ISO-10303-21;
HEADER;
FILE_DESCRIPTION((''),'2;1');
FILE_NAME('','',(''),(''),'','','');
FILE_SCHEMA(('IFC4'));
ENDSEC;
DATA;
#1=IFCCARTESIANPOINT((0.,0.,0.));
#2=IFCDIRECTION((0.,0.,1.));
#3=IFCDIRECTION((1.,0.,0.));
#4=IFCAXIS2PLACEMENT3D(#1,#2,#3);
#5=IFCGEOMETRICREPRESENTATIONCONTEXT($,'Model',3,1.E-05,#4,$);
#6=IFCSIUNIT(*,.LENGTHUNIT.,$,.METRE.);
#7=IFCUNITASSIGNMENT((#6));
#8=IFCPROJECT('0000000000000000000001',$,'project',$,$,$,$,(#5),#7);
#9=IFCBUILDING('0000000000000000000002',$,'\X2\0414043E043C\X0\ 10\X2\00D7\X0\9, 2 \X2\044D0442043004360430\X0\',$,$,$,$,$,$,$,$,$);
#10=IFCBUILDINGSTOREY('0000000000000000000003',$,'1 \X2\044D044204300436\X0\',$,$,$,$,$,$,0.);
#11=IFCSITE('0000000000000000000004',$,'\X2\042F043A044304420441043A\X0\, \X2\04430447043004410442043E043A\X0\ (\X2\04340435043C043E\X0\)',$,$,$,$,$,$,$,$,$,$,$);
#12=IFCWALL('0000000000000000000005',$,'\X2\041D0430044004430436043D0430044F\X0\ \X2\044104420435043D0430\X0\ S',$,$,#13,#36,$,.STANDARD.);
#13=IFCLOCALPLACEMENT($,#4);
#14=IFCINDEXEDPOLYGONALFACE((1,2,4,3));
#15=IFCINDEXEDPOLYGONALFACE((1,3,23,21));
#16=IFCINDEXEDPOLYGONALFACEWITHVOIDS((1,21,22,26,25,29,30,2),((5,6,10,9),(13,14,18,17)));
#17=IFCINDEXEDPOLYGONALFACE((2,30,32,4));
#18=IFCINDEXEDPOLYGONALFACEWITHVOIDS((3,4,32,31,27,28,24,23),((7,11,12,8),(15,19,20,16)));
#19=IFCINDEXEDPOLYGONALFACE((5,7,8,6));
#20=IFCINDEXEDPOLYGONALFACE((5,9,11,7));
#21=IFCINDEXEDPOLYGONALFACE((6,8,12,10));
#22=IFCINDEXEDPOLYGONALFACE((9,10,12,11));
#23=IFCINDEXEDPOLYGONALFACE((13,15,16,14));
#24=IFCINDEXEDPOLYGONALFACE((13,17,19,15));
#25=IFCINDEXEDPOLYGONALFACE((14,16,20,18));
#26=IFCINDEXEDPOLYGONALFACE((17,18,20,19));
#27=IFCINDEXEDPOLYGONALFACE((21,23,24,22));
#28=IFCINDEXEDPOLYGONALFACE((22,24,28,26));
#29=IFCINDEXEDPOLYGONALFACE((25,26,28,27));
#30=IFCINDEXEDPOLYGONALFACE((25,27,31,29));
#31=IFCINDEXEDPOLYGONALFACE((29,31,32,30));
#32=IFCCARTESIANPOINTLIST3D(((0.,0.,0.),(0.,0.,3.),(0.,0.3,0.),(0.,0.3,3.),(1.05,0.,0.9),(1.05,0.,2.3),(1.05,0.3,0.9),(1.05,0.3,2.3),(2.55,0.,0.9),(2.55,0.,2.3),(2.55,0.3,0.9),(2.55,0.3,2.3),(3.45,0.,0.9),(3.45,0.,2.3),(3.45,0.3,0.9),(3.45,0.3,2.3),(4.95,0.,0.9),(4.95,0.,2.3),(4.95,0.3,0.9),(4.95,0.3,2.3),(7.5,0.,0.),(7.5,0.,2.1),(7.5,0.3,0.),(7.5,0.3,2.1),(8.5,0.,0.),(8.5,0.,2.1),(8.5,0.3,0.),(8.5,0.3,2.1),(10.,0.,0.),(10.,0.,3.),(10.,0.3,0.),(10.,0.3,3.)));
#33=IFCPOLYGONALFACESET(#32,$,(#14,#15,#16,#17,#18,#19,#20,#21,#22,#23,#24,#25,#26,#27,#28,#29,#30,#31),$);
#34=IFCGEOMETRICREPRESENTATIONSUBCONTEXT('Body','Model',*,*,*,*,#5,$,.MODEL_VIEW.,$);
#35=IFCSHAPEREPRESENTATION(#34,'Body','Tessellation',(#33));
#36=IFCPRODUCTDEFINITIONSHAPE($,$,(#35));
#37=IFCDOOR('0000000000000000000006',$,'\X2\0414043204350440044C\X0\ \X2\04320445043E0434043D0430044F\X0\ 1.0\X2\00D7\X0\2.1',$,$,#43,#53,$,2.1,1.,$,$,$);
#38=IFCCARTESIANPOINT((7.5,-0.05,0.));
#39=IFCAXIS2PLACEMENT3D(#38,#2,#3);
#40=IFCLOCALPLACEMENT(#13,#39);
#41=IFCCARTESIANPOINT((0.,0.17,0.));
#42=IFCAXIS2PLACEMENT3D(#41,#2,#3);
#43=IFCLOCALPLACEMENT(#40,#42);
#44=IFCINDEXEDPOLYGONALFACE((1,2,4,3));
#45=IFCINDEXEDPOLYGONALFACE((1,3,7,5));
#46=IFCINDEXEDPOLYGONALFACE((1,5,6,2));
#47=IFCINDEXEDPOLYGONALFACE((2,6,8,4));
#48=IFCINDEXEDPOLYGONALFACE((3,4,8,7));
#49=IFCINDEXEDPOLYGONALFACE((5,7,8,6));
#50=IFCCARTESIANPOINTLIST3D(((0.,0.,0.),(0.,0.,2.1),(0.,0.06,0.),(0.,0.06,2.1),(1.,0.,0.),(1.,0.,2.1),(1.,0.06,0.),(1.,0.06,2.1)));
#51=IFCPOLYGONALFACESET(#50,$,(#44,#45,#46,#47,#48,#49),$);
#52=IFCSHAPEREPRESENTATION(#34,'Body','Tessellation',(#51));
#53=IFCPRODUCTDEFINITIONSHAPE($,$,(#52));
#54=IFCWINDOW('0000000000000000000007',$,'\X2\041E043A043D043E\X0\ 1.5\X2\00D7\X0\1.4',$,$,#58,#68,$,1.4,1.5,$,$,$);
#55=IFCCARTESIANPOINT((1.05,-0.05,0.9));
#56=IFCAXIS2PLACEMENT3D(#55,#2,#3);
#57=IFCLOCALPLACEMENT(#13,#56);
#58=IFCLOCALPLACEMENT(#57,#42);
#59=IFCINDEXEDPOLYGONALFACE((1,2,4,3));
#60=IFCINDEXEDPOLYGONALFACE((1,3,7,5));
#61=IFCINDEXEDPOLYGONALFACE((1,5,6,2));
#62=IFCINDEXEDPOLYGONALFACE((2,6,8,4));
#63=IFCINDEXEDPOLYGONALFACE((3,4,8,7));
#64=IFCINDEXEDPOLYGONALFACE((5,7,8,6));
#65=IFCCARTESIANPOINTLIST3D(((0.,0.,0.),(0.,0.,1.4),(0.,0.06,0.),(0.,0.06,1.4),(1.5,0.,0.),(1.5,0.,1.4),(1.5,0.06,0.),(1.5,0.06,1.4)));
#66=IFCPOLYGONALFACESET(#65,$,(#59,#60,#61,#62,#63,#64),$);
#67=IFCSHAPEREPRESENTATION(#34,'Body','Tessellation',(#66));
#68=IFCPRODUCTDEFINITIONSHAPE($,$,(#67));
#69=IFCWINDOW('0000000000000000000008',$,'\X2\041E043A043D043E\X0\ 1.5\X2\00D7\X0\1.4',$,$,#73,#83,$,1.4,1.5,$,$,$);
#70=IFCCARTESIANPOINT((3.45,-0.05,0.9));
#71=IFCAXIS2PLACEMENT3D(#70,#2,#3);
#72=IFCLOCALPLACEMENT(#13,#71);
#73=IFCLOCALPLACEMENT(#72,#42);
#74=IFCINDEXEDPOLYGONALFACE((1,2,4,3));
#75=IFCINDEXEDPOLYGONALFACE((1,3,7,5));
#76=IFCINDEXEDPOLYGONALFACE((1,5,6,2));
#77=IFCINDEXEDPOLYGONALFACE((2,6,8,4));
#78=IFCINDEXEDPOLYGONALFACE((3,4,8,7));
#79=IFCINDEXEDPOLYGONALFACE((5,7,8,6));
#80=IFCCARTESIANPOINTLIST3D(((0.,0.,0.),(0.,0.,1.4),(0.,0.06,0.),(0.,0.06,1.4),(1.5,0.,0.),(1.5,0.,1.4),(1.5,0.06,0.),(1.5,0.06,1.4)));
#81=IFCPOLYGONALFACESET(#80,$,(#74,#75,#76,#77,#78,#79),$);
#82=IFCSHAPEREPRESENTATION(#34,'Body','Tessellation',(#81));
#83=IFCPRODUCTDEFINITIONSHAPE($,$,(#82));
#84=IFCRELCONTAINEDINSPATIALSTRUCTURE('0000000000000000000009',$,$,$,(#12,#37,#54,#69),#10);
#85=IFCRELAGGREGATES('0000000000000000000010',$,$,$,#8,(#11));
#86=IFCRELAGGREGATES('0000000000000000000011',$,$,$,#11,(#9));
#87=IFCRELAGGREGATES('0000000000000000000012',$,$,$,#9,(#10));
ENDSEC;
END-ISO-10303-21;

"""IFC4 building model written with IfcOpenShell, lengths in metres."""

from ifc_helpers import new_model, si_unit, frame, origin_with_axes, place, context, subcontext, project, spatial, indexed_curve, outline, extrude, element, fill, save


model = new_model("IFC4")

# Units and contexts
model_context = context("Model", 3, precision=1e-05, world=origin_with_axes())
body_context = subcontext(model_context, "Body", "Model", "MODEL_VIEW")
ifc_project = project(units=[si_unit("LENGTHUNIT", "METRE")], contexts=[model_context])

# Site, building, storey
site = spatial("IfcSite", under=ifc_project, Name="Якутск, участок (демо)")
building = spatial("IfcBuilding", under=site, Name="Дом 10×9, 2 этажа")
storey = spatial("IfcBuildingStorey", under=building, Name="1 этаж", Elevation=0.0)

# Wall, openings, door, windows
wall_1_placement = place(None, origin_with_axes())
wall_1 = element("IfcWall", 1, at=wall_1_placement, inside=storey, Name="Наружная стена S", PredefinedType="STANDARD", context=body_context, shape_type="SweptSolid", body=[
    extrude(outline(indexed_curve([(0.0, 0.0), (0.0, 0.3), (10.0, 0.3), (10.0, 0.0), (0.0, 0.0)], self_intersect=False)), origin_with_axes(), (0.0, 0.0, 1.0), 3.0),
])
opening_1_placement = place(wall_1_placement, frame((7.5, -0.05, 0.0), z_axis=(0.0, 0.0, 1.0), x_axis=(1.0, 0.0, 0.0)))
opening_1 = element("IfcOpeningElement", 2, at=opening_1_placement, cuts=wall_1, context=body_context, shape_type="SweptSolid", body=[
    extrude(outline(indexed_curve([(0.0, 0.0), (0.0, 0.4), (1.0, 0.4), (1.0, 0.0), (0.0, 0.0)], self_intersect=False)), origin_with_axes(), (0.0, 0.0, 1.0), 2.1),
])
opening_2_placement = place(wall_1_placement, frame((1.05, -0.05, 0.9), z_axis=(0.0, 0.0, 1.0), x_axis=(1.0, 0.0, 0.0)))
opening_2 = element("IfcOpeningElement", 3, at=opening_2_placement, cuts=wall_1, context=body_context, shape_type="SweptSolid", body=[
    extrude(outline(indexed_curve([(0.0, 0.0), (0.0, 0.4), (1.5, 0.4), (1.5, 0.0), (0.0, 0.0)], self_intersect=False)), origin_with_axes(), (0.0, 0.0, 1.0), 1.4),
])
opening_3_placement = place(wall_1_placement, frame((3.45, -0.05, 0.9), z_axis=(0.0, 0.0, 1.0), x_axis=(1.0, 0.0, 0.0)))
opening_3 = element("IfcOpeningElement", 4, at=opening_3_placement, cuts=wall_1, context=body_context, shape_type="SweptSolid", body=[
    extrude(outline(indexed_curve([(0.0, 0.0), (0.0, 0.4), (1.5, 0.4), (1.5, 0.0), (0.0, 0.0)], self_intersect=False)), origin_with_axes(), (0.0, 0.0, 1.0), 1.4),
])
door_1_placement = place(opening_1_placement, frame((0.0, 0.17, 0.0), z_axis=(0.0, 0.0, 1.0), x_axis=(1.0, 0.0, 0.0)))
door_1 = element("IfcDoor", 5, at=door_1_placement, inside=storey, Name="Дверь входная 1.0×2.1", OverallHeight=2.1, OverallWidth=1.0, context=body_context, shape_type="SweptSolid", body=[
    extrude(outline(indexed_curve([(0.0, 0.0), (0.0, 0.06), (1.0, 0.06), (1.0, 0.0), (0.0, 0.0)], self_intersect=False)), origin_with_axes(), (0.0, 0.0, 1.0), 2.1),
])
fill(opening_1, door_1)
window_1_placement = place(opening_2_placement, frame((0.0, 0.17, 0.0), z_axis=(0.0, 0.0, 1.0), x_axis=(1.0, 0.0, 0.0)))
window_1 = element("IfcWindow", 6, at=window_1_placement, inside=storey, Name="Окно 1.5×1.4", OverallHeight=1.4, OverallWidth=1.5, context=body_context, shape_type="SweptSolid", body=[
    extrude(outline(indexed_curve([(0.0, 0.0), (0.0, 0.06), (1.5, 0.06), (1.5, 0.0), (0.0, 0.0)], self_intersect=False)), origin_with_axes(), (0.0, 0.0, 1.0), 1.4),
])
fill(opening_2, window_1)
window_2_placement = place(opening_3_placement, frame((0.0, 0.17, 0.0), z_axis=(0.0, 0.0, 1.0), x_axis=(1.0, 0.0, 0.0)))
window_2 = element("IfcWindow", 7, at=window_2_placement, inside=storey, Name="Окно 1.5×1.4", OverallHeight=1.4, OverallWidth=1.5, context=body_context, shape_type="SweptSolid", body=[
    extrude(outline(indexed_curve([(0.0, 0.0), (0.0, 0.06), (1.5, 0.06), (1.5, 0.0), (0.0, 0.0)], self_intersect=False)), origin_with_axes(), (0.0, 0.0, 1.0), 1.4),
])
fill(opening_3, window_2)

save(model, "model.ifc")
